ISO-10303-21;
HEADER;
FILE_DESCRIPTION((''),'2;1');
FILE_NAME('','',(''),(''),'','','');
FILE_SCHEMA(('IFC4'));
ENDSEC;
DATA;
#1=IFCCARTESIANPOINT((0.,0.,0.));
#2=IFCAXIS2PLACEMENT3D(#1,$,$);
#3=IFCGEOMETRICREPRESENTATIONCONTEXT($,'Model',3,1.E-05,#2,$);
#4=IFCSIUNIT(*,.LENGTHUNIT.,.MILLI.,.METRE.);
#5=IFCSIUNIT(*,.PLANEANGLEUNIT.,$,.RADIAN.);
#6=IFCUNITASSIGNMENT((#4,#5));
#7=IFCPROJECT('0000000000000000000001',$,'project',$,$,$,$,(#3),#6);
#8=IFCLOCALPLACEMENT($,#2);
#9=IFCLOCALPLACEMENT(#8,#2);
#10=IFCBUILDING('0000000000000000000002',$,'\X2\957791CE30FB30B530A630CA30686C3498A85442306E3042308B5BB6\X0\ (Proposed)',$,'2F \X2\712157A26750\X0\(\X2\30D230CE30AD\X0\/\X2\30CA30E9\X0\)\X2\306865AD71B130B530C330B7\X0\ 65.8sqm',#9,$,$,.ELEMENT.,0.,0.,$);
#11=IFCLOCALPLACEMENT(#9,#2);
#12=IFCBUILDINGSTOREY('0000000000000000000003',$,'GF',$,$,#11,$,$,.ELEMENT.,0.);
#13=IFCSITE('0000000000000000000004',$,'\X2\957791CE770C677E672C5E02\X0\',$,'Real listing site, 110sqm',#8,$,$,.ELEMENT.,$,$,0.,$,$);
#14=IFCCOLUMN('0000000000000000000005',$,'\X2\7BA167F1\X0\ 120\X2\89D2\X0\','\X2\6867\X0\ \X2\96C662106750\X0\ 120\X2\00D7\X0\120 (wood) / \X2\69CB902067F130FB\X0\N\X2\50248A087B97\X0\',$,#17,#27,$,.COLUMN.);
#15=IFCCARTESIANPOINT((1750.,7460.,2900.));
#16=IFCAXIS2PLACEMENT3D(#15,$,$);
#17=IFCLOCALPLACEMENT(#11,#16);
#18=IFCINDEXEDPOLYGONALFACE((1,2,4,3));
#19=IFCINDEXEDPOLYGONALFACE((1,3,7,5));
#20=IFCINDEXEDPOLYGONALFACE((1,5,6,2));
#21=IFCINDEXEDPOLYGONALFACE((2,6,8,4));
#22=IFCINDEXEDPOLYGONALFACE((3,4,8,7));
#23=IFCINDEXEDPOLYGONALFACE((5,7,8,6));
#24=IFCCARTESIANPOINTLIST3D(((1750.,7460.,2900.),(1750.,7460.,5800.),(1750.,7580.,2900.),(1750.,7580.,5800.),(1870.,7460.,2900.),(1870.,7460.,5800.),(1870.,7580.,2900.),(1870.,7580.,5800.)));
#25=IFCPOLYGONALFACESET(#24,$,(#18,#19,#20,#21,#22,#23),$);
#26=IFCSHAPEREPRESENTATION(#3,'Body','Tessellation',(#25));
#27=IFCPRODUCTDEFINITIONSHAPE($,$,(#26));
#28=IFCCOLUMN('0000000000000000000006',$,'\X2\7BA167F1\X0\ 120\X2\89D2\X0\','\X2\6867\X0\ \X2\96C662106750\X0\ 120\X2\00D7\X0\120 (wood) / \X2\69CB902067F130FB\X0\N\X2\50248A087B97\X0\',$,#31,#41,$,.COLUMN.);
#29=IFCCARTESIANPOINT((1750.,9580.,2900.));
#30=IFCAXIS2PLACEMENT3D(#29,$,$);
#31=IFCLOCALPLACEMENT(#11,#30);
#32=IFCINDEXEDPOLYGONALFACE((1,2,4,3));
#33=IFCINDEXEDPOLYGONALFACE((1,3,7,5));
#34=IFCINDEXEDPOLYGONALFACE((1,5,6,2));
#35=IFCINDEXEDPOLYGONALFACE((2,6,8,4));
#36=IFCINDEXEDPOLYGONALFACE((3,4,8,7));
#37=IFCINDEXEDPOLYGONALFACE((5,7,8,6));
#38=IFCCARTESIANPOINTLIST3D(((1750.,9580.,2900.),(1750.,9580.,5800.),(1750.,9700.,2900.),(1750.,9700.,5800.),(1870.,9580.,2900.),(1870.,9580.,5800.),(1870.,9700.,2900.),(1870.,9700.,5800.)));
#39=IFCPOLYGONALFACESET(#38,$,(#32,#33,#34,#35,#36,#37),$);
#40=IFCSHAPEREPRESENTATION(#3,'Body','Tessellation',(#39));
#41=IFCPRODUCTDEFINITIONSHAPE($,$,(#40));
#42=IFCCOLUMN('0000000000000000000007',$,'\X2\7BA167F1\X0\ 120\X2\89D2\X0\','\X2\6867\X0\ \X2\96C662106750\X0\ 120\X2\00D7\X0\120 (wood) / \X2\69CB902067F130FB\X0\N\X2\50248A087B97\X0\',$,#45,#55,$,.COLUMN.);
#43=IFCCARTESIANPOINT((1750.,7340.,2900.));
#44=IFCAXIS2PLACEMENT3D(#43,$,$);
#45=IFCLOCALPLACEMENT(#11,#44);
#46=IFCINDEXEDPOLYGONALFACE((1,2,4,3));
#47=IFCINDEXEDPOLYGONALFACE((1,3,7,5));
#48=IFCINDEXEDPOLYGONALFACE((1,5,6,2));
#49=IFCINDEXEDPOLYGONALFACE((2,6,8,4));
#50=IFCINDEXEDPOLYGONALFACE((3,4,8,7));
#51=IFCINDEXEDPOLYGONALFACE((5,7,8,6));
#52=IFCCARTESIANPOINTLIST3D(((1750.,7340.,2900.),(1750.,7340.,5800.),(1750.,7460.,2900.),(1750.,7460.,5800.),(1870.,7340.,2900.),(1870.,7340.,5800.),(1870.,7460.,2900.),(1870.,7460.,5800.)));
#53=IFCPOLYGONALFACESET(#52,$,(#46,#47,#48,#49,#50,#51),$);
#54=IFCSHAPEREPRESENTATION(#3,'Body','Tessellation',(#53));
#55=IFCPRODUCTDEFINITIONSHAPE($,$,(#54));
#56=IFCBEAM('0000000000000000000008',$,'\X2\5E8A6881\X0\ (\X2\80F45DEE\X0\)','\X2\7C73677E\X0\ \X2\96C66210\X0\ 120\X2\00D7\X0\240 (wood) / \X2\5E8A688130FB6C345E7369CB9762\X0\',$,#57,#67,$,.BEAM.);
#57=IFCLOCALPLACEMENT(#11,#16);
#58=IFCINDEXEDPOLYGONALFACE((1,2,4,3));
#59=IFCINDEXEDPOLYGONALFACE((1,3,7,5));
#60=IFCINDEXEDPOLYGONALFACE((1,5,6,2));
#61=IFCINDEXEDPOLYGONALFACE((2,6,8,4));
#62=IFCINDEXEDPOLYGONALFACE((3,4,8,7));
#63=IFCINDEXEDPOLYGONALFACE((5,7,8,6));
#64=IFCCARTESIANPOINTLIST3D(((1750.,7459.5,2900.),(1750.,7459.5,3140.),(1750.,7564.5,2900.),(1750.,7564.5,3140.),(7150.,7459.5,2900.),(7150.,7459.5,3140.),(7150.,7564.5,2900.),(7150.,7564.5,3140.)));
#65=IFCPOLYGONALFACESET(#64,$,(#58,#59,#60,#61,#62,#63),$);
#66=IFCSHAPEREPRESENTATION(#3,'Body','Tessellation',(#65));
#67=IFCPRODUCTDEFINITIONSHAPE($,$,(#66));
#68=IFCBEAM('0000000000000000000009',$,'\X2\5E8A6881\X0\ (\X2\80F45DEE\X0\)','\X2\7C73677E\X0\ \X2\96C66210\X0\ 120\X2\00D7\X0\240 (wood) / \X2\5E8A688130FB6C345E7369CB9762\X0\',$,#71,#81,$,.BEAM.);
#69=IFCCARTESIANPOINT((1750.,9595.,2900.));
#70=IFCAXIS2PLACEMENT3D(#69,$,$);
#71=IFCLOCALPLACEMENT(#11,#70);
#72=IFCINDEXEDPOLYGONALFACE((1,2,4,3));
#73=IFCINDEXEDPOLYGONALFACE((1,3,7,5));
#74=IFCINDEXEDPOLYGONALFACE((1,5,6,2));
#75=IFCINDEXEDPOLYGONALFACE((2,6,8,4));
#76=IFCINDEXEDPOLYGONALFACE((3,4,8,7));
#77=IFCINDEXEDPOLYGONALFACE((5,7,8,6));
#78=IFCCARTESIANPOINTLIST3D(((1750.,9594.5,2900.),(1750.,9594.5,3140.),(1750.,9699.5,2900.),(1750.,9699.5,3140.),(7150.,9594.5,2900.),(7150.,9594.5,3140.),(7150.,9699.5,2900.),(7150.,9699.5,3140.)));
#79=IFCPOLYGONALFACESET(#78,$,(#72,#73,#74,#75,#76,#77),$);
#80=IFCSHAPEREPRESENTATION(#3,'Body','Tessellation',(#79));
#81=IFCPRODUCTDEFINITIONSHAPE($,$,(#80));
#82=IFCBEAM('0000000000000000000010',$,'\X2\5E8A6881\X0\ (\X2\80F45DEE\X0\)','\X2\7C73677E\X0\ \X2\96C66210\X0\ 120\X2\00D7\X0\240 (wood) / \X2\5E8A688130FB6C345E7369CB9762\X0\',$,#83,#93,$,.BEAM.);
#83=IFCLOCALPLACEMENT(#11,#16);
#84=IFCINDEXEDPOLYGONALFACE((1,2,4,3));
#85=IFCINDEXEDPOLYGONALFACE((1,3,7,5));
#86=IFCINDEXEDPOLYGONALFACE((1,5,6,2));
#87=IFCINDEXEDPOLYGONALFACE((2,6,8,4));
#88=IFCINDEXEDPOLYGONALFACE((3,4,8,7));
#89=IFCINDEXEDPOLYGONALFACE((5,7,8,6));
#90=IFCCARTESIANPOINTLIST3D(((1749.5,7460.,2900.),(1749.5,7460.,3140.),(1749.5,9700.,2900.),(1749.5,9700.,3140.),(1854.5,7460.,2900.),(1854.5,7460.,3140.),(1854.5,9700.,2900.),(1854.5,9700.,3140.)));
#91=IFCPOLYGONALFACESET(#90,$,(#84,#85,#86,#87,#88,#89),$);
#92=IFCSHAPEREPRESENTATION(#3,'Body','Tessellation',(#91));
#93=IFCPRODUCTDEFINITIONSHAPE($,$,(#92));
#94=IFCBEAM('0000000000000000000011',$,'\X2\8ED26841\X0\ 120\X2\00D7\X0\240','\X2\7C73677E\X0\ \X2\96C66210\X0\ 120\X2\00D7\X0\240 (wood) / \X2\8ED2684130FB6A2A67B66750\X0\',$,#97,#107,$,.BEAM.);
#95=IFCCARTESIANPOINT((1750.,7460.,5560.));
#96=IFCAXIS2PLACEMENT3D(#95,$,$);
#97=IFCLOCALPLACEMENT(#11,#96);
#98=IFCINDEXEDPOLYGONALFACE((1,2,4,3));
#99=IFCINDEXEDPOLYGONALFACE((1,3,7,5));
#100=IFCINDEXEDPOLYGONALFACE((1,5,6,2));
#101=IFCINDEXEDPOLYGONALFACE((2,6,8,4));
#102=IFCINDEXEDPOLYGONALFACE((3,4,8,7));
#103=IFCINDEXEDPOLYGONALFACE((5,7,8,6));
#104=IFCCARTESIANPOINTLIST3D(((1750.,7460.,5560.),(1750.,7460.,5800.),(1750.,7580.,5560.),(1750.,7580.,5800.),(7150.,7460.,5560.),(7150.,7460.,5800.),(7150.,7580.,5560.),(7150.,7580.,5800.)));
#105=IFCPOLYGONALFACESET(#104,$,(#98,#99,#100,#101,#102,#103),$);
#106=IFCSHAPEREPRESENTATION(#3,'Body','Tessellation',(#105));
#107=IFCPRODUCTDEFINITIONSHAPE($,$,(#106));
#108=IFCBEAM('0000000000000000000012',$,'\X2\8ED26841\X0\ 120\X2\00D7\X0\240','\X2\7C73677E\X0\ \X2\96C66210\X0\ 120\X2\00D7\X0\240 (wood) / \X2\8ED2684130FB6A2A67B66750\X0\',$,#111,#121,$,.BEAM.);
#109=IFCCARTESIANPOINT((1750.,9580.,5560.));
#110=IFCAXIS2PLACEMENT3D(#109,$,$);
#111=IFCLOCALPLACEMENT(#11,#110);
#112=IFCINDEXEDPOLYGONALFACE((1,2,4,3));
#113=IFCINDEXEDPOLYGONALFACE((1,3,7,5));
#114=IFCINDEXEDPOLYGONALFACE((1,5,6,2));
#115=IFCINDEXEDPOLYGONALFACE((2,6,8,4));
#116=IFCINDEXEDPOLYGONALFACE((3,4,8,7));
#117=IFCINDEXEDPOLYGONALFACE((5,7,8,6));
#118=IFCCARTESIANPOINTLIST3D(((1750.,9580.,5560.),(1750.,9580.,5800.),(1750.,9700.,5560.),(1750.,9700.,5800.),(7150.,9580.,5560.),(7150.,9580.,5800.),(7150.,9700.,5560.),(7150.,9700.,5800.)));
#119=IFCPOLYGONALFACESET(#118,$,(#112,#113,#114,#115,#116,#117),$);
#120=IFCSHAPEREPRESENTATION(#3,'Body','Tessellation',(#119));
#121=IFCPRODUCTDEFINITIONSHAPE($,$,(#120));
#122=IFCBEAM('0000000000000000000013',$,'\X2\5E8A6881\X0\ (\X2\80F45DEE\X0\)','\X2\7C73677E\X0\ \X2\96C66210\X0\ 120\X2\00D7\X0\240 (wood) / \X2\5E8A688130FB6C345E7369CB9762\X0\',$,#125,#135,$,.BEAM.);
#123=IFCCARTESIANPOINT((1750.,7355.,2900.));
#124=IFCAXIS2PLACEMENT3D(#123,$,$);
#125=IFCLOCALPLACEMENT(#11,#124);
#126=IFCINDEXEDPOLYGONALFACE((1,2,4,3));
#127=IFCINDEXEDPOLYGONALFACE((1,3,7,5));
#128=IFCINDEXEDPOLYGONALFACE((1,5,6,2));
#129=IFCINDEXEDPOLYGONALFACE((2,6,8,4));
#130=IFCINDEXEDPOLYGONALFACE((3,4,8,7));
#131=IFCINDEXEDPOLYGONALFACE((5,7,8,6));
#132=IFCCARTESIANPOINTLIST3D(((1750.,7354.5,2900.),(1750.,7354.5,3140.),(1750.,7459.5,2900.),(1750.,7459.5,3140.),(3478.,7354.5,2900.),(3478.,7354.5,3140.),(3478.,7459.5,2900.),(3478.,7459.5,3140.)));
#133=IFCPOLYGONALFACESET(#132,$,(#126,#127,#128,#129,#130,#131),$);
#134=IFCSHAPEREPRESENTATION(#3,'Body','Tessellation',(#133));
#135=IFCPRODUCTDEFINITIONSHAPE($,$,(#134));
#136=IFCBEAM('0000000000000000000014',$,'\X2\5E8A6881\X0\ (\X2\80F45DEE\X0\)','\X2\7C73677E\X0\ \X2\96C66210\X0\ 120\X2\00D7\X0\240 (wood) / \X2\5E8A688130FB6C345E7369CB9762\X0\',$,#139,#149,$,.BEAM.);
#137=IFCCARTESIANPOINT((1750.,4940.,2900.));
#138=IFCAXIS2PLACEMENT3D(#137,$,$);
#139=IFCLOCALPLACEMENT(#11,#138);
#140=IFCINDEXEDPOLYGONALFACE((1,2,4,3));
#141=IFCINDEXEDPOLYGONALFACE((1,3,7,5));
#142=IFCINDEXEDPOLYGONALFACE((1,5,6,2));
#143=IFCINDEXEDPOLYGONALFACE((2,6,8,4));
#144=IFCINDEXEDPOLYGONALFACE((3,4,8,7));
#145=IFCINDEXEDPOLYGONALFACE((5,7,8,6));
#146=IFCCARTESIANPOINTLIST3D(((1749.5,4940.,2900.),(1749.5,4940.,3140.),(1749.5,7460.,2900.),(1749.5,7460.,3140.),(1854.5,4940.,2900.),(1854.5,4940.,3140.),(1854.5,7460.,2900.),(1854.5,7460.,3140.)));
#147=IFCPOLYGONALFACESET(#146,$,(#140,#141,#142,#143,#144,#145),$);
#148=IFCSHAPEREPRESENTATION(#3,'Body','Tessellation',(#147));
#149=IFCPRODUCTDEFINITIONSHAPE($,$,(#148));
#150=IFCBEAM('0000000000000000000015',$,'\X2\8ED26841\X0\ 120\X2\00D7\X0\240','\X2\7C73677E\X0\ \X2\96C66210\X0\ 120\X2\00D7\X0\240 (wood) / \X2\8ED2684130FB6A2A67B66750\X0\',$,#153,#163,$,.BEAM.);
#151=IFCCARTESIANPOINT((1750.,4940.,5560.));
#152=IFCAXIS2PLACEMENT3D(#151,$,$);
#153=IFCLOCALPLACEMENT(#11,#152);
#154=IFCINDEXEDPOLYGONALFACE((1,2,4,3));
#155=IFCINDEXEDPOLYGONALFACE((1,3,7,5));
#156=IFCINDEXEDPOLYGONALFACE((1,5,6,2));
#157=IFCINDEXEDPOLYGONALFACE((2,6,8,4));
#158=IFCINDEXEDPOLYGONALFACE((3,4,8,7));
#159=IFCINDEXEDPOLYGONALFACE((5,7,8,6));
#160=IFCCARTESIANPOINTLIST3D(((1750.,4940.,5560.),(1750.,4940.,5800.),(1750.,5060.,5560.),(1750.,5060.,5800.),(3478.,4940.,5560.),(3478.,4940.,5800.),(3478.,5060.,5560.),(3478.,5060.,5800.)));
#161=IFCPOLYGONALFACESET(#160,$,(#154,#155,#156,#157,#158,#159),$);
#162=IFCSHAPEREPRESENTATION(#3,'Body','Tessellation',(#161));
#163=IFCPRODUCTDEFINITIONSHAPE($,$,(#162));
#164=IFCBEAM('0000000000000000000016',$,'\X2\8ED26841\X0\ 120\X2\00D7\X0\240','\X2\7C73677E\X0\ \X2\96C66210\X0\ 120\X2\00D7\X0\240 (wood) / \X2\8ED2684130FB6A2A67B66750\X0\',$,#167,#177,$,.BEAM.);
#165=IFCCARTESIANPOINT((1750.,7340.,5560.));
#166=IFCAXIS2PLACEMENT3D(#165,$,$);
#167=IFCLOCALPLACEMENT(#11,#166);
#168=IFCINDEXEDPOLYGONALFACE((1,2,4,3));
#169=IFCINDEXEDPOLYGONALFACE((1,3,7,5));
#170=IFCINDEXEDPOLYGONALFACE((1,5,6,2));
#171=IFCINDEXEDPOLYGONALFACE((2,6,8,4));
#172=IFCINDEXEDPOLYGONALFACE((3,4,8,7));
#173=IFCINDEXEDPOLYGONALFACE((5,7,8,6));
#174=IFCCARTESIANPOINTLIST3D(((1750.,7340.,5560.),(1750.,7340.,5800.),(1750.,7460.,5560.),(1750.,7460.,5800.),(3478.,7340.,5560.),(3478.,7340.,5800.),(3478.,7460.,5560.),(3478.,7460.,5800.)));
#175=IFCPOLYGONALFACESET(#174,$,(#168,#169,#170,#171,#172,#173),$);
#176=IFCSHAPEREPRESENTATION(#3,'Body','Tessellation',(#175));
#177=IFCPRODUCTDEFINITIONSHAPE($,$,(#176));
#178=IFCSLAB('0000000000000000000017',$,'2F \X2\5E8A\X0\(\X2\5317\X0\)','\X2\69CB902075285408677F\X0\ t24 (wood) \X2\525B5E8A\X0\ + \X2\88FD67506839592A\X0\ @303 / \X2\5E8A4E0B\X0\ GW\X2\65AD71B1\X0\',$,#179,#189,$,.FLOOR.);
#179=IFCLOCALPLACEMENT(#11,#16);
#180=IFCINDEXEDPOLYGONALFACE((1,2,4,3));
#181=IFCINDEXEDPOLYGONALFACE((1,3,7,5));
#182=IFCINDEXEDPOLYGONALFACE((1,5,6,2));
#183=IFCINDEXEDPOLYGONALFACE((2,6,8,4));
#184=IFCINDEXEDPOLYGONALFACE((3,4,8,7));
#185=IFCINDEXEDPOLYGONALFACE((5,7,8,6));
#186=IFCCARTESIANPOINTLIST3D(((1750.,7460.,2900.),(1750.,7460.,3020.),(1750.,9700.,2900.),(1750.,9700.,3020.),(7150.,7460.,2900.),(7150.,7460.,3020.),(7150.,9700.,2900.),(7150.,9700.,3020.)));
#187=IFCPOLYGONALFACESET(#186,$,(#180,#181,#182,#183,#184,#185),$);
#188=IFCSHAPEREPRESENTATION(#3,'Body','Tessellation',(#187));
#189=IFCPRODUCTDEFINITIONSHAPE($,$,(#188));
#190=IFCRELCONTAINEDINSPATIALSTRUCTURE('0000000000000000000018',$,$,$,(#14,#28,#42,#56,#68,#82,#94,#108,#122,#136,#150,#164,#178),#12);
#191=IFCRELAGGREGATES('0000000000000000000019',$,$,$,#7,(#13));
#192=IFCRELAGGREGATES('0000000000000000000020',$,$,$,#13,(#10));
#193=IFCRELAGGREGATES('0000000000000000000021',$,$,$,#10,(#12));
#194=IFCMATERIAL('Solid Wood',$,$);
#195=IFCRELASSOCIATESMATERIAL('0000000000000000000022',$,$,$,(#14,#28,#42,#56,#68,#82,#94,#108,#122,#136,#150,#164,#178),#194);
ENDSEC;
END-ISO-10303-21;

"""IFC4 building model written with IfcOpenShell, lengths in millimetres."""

from ifc_helpers import new_model, si_unit, frame, frame_2d, origin, place, context, project, spatial, rectangle, extrude, material, element, save


model = new_model("IFC4")

# Units and contexts
model_context = context("Model", 3, precision=1e-05, world=origin())
ifc_project = project(units=[si_unit("LENGTHUNIT", "METRE", prefix="MILLI"), si_unit("PLANEANGLEUNIT", "RADIAN")], contexts=[model_context])

# Site, building, storey
site_placement = place(None, origin())
site = spatial("IfcSite", under=ifc_project, at=site_placement, Name="長野県松本市", ObjectType="Real listing site, 110sqm", CompositionType="ELEMENT", RefElevation=0.0)
building_placement = place(site_placement, origin())
building = spatial("IfcBuilding", under=site, at=building_placement, Name="長野・サウナと水風呂のある家 (Proposed)", ObjectType="2F 無垢材(ヒノキ/ナラ)と断熱サッシ 65.8sqm", CompositionType="ELEMENT", ElevationOfRefHeight=0.0, ElevationOfTerrain=0.0)
storey_placement = place(building_placement, origin())
storey = spatial("IfcBuildingStorey", under=building, at=storey_placement, Name="GF", CompositionType="ELEMENT", Elevation=0.0)

# Columns
ifc_material_1 = material(Name="Solid Wood")
column_1_placement = place(storey_placement, frame((1750.0, 7460.0, 2900.0)))
element("IfcColumn", 1, at=column_1_placement, inside=storey, material=ifc_material_1, Name="管柱 120角", Description="桧 集成材 120×120 (wood) / 構造柱・N値計算", PredefinedType="COLUMN", context=model_context, shape_type="SweptSolid", body=[
    extrude(rectangle(XDim=120.0, YDim=120.0, at=frame_2d((60.0, 60.0))), frame((1750.0, 7460.0, 2900.0)), (0.0, 0.0, 1.0), 2900.0),
])
column_2_placement = place(storey_placement, frame((1750.0, 9580.0, 2900.0)))
element("IfcColumn", 2, at=column_2_placement, inside=storey, material=ifc_material_1, Name="管柱 120角", Description="桧 集成材 120×120 (wood) / 構造柱・N値計算", PredefinedType="COLUMN", context=model_context, shape_type="SweptSolid", body=[
    extrude(rectangle(XDim=120.0, YDim=120.0, at=frame_2d((60.0, 60.0))), frame((1750.0, 9580.0, 2900.0)), (0.0, 0.0, 1.0), 2900.0),
])
column_3_placement = place(storey_placement, frame((1750.0, 7340.0, 2900.0)))
element("IfcColumn", 3, at=column_3_placement, inside=storey, material=ifc_material_1, Name="管柱 120角", Description="桧 集成材 120×120 (wood) / 構造柱・N値計算", PredefinedType="COLUMN", context=model_context, shape_type="SweptSolid", body=[
    extrude(rectangle(XDim=120.0, YDim=120.0, at=frame_2d((60.0, 60.0))), frame((1750.0, 7340.0, 2900.0)), (0.0, 0.0, 1.0), 2900.0),
])

# Beams
beam_1_placement = place(storey_placement, frame((1750.0, 7460.0, 2900.0)))
element("IfcBeam", 4, at=beam_1_placement, inside=storey, material=ifc_material_1, Name="床梁 (胴差)", Description="米松 集成 120×240 (wood) / 床梁・水平構面", PredefinedType="BEAM", context=model_context, shape_type="SweptSolid", body=[
    extrude(rectangle(XDim=5400.0, YDim=105.0, at=frame_2d((2700.0, 52.0))), frame((1750.0, 7460.0, 2900.0)), (0.0, 0.0, 1.0), 240.0),
])
beam_2_placement = place(storey_placement, frame((1750.0, 9595.0, 2900.0)))
element("IfcBeam", 5, at=beam_2_placement, inside=storey, material=ifc_material_1, Name="床梁 (胴差)", Description="米松 集成 120×240 (wood) / 床梁・水平構面", PredefinedType="BEAM", context=model_context, shape_type="SweptSolid", body=[
    extrude(rectangle(XDim=5400.0, YDim=105.0, at=frame_2d((2700.0, 52.0))), frame((1750.0, 9595.0, 2900.0)), (0.0, 0.0, 1.0), 240.0),
])
beam_3_placement = place(storey_placement, frame((1750.0, 7460.0, 2900.0)))
element("IfcBeam", 6, at=beam_3_placement, inside=storey, material=ifc_material_1, Name="床梁 (胴差)", Description="米松 集成 120×240 (wood) / 床梁・水平構面", PredefinedType="BEAM", context=model_context, shape_type="SweptSolid", body=[
    extrude(rectangle(XDim=105.0, YDim=2240.0, at=frame_2d((52.0, 1120.0))), frame((1750.0, 7460.0, 2900.0)), (0.0, 0.0, 1.0), 240.0),
])
beam_4_placement = place(storey_placement, frame((1750.0, 7460.0, 5560.0)))
element("IfcBeam", 7, at=beam_4_placement, inside=storey, material=ifc_material_1, Name="軒桁 120×240", Description="米松 集成 120×240 (wood) / 軒桁・横架材", PredefinedType="BEAM", context=model_context, shape_type="SweptSolid", body=[
    extrude(rectangle(XDim=5400.0, YDim=120.0, at=frame_2d((2700.0, 60.0))), frame((1750.0, 7460.0, 5560.0)), (0.0, 0.0, 1.0), 240.0),
])
beam_5_placement = place(storey_placement, frame((1750.0, 9580.0, 5560.0)))
element("IfcBeam", 8, at=beam_5_placement, inside=storey, material=ifc_material_1, Name="軒桁 120×240", Description="米松 集成 120×240 (wood) / 軒桁・横架材", PredefinedType="BEAM", context=model_context, shape_type="SweptSolid", body=[
    extrude(rectangle(XDim=5400.0, YDim=120.0, at=frame_2d((2700.0, 60.0))), frame((1750.0, 9580.0, 5560.0)), (0.0, 0.0, 1.0), 240.0),
])
beam_6_placement = place(storey_placement, frame((1750.0, 7355.0, 2900.0)))
element("IfcBeam", 9, at=beam_6_placement, inside=storey, material=ifc_material_1, Name="床梁 (胴差)", Description="米松 集成 120×240 (wood) / 床梁・水平構面", PredefinedType="BEAM", context=model_context, shape_type="SweptSolid", body=[
    extrude(rectangle(XDim=1728.0, YDim=105.0, at=frame_2d((864.0, 52.0))), frame((1750.0, 7355.0, 2900.0)), (0.0, 0.0, 1.0), 240.0),
])
beam_7_placement = place(storey_placement, frame((1750.0, 4940.0, 2900.0)))
element("IfcBeam", 10, at=beam_7_placement, inside=storey, material=ifc_material_1, Name="床梁 (胴差)", Description="米松 集成 120×240 (wood) / 床梁・水平構面", PredefinedType="BEAM", context=model_context, shape_type="SweptSolid", body=[
    extrude(rectangle(XDim=105.0, YDim=2520.0, at=frame_2d((52.0, 1260.0))), frame((1750.0, 4940.0, 2900.0)), (0.0, 0.0, 1.0), 240.0),
])
beam_8_placement = place(storey_placement, frame((1750.0, 4940.0, 5560.0)))
element("IfcBeam", 11, at=beam_8_placement, inside=storey, material=ifc_material_1, Name="軒桁 120×240", Description="米松 集成 120×240 (wood) / 軒桁・横架材", PredefinedType="BEAM", context=model_context, shape_type="SweptSolid", body=[
    extrude(rectangle(XDim=1728.0, YDim=120.0, at=frame_2d((864.0, 60.0))), frame((1750.0, 4940.0, 5560.0)), (0.0, 0.0, 1.0), 240.0),
])
beam_9_placement = place(storey_placement, frame((1750.0, 7340.0, 5560.0)))
element("IfcBeam", 12, at=beam_9_placement, inside=storey, material=ifc_material_1, Name="軒桁 120×240", Description="米松 集成 120×240 (wood) / 軒桁・横架材", PredefinedType="BEAM", context=model_context, shape_type="SweptSolid", body=[
    extrude(rectangle(XDim=1728.0, YDim=120.0, at=frame_2d((864.0, 60.0))), frame((1750.0, 7340.0, 5560.0)), (0.0, 0.0, 1.0), 240.0),
])

# Slab
slab_placement = place(storey_placement, frame((1750.0, 7460.0, 2900.0)))
element("IfcSlab", 13, at=slab_placement, inside=storey, material=ifc_material_1, Name="2F 床(北)", Description="構造用合板 t24 (wood) 剛床 + 製材根太 @303 / 床下 GW断熱", PredefinedType="FLOOR", context=model_context, shape_type="SweptSolid", body=[
    extrude(rectangle(XDim=5400.0, YDim=2240.0, at=frame_2d((2700.0, 1120.0))), frame((1750.0, 7460.0, 2900.0)), (0.0, 0.0, 1.0), 120.0),
])

save(model, "model.ifc")
